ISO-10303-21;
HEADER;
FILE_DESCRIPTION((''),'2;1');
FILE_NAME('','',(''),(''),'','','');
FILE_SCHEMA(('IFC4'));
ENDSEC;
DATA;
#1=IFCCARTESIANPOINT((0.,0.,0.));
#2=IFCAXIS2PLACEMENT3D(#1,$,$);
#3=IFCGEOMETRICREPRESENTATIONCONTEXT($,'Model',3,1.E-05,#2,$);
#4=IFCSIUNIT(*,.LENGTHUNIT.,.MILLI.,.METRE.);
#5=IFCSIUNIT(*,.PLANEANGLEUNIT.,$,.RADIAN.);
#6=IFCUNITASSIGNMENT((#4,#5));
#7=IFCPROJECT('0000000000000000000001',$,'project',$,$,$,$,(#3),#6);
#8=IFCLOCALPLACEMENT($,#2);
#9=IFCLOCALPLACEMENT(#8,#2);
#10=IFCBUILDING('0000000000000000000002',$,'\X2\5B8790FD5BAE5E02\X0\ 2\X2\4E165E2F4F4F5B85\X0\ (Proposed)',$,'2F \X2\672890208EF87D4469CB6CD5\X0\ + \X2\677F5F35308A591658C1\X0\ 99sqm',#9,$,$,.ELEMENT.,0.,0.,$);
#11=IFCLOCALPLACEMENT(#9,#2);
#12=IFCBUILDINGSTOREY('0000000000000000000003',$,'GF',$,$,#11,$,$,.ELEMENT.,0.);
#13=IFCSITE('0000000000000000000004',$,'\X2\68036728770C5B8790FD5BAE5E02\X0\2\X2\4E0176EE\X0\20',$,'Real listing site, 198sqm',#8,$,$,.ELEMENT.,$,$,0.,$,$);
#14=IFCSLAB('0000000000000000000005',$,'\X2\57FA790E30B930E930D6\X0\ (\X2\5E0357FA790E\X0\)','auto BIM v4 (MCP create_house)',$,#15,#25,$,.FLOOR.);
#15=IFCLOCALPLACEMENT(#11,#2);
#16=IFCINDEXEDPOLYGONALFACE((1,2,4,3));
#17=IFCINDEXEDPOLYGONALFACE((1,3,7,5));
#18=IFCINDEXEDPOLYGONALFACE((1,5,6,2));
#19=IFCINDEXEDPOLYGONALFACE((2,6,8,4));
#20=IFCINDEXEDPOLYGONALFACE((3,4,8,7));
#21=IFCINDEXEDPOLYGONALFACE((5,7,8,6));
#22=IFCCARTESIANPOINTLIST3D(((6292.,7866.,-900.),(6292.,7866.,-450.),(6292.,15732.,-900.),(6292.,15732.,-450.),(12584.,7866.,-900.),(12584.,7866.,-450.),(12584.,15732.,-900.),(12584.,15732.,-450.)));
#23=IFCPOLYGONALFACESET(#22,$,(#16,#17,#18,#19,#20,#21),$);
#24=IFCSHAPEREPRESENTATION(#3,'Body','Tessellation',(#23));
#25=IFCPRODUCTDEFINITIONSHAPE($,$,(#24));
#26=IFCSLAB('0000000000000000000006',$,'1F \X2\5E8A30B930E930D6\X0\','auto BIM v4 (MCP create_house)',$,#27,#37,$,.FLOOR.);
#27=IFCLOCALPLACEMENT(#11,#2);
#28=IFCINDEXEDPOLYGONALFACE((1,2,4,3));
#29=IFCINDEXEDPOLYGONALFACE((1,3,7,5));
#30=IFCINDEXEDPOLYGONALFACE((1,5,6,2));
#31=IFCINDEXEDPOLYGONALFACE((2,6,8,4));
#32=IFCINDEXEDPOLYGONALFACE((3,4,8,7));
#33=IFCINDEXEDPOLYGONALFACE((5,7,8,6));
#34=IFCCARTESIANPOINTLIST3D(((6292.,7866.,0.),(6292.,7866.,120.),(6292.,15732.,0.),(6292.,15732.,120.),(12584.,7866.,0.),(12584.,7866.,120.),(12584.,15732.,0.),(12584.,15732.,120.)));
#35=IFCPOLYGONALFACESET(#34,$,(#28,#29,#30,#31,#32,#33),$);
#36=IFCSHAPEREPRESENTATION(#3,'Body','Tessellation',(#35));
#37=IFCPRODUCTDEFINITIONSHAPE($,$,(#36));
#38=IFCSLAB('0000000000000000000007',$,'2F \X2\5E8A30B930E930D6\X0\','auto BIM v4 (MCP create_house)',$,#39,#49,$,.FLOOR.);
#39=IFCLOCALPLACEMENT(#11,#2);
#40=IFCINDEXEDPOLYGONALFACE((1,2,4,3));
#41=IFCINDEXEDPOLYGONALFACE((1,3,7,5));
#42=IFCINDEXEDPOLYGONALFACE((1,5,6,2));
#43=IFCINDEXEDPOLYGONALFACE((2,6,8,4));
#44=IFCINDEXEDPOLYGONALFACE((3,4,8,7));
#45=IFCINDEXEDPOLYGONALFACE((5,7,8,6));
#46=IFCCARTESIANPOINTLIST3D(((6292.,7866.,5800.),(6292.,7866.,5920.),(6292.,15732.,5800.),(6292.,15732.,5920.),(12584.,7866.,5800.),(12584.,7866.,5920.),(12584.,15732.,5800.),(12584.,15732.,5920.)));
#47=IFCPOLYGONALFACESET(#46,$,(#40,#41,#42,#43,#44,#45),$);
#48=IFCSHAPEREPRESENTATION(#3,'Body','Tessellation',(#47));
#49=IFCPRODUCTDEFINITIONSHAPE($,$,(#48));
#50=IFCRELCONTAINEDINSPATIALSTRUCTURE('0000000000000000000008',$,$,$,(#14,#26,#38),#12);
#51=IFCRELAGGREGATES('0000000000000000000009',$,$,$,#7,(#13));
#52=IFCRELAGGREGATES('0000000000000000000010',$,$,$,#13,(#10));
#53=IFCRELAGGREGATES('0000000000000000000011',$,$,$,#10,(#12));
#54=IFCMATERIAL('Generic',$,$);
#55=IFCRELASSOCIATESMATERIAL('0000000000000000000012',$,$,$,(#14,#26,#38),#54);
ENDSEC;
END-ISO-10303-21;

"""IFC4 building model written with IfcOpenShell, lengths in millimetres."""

from ifc_helpers import new_model, si_unit, frame, frame_2d, origin, place, context, project, spatial, rectangle, extrude, material, element, save


model = new_model("IFC4")

# Units and contexts
model_context = context("Model", 3, precision=1e-05, world=origin())
ifc_project = project(units=[si_unit("LENGTHUNIT", "METRE", prefix="MILLI"), si_unit("PLANEANGLEUNIT", "RADIAN")], contexts=[model_context])

# Site, building, storey
site_placement = place(None, origin())
site = spatial("IfcSite", under=ifc_project, at=site_placement, Name="栃木県宇都宮市2丁目20", ObjectType="Real listing site, 198sqm", CompositionType="ELEMENT", RefElevation=0.0)
building_placement = place(site_placement, origin())
building = spatial("IfcBuilding", under=site, at=building_placement, Name="宇都宮市 2世帯住宅 (Proposed)", ObjectType="2F 木造軸組構法 + 板張り外壁 99sqm", CompositionType="ELEMENT", ElevationOfRefHeight=0.0, ElevationOfTerrain=0.0)
storey_placement = place(building_placement, origin())
storey = spatial("IfcBuildingStorey", under=building, at=storey_placement, Name="GF", CompositionType="ELEMENT", Elevation=0.0)

# Slabs
ifc_material = material(Name="Generic")
slab_1_placement = place(storey_placement, frame((3146.0, 3933.0, -450.0)))
element("IfcSlab", 1, at=slab_1_placement, inside=storey, material=ifc_material, Name="基礎スラブ (布基礎)", Description="auto BIM v4 (MCP create_house)", PredefinedType="FLOOR", context=model_context, shape_type="SweptSolid", body=[
    extrude(rectangle(XDim=6292.0, YDim=7866.0, at=frame_2d((3146.0, 3933.0))), frame((3146.0, 3933.0, -450.0)), (0.0, 0.0, 1.0), 450.0),
])
slab_2_placement = place(storey_placement, frame((3146.0, 3933.0, 0.0)))
element("IfcSlab", 2, at=slab_2_placement, inside=storey, material=ifc_material, Name="1F 床スラブ", Description="auto BIM v4 (MCP create_house)", PredefinedType="FLOOR", context=model_context, shape_type="SweptSolid", body=[
    extrude(rectangle(XDim=6292.0, YDim=7866.0, at=frame_2d((3146.0, 3933.0))), frame((3146.0, 3933.0, 0.0)), (0.0, 0.0, 1.0), 120.0),
])
slab_3_placement = place(storey_placement, frame((3146.0, 3933.0, 2900.0)))
element("IfcSlab", 3, at=slab_3_placement, inside=storey, material=ifc_material, Name="2F 床スラブ", Description="auto BIM v4 (MCP create_house)", PredefinedType="FLOOR", context=model_context, shape_type="SweptSolid", body=[
    extrude(rectangle(XDim=6292.0, YDim=7866.0, at=frame_2d((3146.0, 3933.0))), frame((3146.0, 3933.0, 2900.0)), (0.0, 0.0, 1.0), 120.0),
])

save(model, "model.ifc")
